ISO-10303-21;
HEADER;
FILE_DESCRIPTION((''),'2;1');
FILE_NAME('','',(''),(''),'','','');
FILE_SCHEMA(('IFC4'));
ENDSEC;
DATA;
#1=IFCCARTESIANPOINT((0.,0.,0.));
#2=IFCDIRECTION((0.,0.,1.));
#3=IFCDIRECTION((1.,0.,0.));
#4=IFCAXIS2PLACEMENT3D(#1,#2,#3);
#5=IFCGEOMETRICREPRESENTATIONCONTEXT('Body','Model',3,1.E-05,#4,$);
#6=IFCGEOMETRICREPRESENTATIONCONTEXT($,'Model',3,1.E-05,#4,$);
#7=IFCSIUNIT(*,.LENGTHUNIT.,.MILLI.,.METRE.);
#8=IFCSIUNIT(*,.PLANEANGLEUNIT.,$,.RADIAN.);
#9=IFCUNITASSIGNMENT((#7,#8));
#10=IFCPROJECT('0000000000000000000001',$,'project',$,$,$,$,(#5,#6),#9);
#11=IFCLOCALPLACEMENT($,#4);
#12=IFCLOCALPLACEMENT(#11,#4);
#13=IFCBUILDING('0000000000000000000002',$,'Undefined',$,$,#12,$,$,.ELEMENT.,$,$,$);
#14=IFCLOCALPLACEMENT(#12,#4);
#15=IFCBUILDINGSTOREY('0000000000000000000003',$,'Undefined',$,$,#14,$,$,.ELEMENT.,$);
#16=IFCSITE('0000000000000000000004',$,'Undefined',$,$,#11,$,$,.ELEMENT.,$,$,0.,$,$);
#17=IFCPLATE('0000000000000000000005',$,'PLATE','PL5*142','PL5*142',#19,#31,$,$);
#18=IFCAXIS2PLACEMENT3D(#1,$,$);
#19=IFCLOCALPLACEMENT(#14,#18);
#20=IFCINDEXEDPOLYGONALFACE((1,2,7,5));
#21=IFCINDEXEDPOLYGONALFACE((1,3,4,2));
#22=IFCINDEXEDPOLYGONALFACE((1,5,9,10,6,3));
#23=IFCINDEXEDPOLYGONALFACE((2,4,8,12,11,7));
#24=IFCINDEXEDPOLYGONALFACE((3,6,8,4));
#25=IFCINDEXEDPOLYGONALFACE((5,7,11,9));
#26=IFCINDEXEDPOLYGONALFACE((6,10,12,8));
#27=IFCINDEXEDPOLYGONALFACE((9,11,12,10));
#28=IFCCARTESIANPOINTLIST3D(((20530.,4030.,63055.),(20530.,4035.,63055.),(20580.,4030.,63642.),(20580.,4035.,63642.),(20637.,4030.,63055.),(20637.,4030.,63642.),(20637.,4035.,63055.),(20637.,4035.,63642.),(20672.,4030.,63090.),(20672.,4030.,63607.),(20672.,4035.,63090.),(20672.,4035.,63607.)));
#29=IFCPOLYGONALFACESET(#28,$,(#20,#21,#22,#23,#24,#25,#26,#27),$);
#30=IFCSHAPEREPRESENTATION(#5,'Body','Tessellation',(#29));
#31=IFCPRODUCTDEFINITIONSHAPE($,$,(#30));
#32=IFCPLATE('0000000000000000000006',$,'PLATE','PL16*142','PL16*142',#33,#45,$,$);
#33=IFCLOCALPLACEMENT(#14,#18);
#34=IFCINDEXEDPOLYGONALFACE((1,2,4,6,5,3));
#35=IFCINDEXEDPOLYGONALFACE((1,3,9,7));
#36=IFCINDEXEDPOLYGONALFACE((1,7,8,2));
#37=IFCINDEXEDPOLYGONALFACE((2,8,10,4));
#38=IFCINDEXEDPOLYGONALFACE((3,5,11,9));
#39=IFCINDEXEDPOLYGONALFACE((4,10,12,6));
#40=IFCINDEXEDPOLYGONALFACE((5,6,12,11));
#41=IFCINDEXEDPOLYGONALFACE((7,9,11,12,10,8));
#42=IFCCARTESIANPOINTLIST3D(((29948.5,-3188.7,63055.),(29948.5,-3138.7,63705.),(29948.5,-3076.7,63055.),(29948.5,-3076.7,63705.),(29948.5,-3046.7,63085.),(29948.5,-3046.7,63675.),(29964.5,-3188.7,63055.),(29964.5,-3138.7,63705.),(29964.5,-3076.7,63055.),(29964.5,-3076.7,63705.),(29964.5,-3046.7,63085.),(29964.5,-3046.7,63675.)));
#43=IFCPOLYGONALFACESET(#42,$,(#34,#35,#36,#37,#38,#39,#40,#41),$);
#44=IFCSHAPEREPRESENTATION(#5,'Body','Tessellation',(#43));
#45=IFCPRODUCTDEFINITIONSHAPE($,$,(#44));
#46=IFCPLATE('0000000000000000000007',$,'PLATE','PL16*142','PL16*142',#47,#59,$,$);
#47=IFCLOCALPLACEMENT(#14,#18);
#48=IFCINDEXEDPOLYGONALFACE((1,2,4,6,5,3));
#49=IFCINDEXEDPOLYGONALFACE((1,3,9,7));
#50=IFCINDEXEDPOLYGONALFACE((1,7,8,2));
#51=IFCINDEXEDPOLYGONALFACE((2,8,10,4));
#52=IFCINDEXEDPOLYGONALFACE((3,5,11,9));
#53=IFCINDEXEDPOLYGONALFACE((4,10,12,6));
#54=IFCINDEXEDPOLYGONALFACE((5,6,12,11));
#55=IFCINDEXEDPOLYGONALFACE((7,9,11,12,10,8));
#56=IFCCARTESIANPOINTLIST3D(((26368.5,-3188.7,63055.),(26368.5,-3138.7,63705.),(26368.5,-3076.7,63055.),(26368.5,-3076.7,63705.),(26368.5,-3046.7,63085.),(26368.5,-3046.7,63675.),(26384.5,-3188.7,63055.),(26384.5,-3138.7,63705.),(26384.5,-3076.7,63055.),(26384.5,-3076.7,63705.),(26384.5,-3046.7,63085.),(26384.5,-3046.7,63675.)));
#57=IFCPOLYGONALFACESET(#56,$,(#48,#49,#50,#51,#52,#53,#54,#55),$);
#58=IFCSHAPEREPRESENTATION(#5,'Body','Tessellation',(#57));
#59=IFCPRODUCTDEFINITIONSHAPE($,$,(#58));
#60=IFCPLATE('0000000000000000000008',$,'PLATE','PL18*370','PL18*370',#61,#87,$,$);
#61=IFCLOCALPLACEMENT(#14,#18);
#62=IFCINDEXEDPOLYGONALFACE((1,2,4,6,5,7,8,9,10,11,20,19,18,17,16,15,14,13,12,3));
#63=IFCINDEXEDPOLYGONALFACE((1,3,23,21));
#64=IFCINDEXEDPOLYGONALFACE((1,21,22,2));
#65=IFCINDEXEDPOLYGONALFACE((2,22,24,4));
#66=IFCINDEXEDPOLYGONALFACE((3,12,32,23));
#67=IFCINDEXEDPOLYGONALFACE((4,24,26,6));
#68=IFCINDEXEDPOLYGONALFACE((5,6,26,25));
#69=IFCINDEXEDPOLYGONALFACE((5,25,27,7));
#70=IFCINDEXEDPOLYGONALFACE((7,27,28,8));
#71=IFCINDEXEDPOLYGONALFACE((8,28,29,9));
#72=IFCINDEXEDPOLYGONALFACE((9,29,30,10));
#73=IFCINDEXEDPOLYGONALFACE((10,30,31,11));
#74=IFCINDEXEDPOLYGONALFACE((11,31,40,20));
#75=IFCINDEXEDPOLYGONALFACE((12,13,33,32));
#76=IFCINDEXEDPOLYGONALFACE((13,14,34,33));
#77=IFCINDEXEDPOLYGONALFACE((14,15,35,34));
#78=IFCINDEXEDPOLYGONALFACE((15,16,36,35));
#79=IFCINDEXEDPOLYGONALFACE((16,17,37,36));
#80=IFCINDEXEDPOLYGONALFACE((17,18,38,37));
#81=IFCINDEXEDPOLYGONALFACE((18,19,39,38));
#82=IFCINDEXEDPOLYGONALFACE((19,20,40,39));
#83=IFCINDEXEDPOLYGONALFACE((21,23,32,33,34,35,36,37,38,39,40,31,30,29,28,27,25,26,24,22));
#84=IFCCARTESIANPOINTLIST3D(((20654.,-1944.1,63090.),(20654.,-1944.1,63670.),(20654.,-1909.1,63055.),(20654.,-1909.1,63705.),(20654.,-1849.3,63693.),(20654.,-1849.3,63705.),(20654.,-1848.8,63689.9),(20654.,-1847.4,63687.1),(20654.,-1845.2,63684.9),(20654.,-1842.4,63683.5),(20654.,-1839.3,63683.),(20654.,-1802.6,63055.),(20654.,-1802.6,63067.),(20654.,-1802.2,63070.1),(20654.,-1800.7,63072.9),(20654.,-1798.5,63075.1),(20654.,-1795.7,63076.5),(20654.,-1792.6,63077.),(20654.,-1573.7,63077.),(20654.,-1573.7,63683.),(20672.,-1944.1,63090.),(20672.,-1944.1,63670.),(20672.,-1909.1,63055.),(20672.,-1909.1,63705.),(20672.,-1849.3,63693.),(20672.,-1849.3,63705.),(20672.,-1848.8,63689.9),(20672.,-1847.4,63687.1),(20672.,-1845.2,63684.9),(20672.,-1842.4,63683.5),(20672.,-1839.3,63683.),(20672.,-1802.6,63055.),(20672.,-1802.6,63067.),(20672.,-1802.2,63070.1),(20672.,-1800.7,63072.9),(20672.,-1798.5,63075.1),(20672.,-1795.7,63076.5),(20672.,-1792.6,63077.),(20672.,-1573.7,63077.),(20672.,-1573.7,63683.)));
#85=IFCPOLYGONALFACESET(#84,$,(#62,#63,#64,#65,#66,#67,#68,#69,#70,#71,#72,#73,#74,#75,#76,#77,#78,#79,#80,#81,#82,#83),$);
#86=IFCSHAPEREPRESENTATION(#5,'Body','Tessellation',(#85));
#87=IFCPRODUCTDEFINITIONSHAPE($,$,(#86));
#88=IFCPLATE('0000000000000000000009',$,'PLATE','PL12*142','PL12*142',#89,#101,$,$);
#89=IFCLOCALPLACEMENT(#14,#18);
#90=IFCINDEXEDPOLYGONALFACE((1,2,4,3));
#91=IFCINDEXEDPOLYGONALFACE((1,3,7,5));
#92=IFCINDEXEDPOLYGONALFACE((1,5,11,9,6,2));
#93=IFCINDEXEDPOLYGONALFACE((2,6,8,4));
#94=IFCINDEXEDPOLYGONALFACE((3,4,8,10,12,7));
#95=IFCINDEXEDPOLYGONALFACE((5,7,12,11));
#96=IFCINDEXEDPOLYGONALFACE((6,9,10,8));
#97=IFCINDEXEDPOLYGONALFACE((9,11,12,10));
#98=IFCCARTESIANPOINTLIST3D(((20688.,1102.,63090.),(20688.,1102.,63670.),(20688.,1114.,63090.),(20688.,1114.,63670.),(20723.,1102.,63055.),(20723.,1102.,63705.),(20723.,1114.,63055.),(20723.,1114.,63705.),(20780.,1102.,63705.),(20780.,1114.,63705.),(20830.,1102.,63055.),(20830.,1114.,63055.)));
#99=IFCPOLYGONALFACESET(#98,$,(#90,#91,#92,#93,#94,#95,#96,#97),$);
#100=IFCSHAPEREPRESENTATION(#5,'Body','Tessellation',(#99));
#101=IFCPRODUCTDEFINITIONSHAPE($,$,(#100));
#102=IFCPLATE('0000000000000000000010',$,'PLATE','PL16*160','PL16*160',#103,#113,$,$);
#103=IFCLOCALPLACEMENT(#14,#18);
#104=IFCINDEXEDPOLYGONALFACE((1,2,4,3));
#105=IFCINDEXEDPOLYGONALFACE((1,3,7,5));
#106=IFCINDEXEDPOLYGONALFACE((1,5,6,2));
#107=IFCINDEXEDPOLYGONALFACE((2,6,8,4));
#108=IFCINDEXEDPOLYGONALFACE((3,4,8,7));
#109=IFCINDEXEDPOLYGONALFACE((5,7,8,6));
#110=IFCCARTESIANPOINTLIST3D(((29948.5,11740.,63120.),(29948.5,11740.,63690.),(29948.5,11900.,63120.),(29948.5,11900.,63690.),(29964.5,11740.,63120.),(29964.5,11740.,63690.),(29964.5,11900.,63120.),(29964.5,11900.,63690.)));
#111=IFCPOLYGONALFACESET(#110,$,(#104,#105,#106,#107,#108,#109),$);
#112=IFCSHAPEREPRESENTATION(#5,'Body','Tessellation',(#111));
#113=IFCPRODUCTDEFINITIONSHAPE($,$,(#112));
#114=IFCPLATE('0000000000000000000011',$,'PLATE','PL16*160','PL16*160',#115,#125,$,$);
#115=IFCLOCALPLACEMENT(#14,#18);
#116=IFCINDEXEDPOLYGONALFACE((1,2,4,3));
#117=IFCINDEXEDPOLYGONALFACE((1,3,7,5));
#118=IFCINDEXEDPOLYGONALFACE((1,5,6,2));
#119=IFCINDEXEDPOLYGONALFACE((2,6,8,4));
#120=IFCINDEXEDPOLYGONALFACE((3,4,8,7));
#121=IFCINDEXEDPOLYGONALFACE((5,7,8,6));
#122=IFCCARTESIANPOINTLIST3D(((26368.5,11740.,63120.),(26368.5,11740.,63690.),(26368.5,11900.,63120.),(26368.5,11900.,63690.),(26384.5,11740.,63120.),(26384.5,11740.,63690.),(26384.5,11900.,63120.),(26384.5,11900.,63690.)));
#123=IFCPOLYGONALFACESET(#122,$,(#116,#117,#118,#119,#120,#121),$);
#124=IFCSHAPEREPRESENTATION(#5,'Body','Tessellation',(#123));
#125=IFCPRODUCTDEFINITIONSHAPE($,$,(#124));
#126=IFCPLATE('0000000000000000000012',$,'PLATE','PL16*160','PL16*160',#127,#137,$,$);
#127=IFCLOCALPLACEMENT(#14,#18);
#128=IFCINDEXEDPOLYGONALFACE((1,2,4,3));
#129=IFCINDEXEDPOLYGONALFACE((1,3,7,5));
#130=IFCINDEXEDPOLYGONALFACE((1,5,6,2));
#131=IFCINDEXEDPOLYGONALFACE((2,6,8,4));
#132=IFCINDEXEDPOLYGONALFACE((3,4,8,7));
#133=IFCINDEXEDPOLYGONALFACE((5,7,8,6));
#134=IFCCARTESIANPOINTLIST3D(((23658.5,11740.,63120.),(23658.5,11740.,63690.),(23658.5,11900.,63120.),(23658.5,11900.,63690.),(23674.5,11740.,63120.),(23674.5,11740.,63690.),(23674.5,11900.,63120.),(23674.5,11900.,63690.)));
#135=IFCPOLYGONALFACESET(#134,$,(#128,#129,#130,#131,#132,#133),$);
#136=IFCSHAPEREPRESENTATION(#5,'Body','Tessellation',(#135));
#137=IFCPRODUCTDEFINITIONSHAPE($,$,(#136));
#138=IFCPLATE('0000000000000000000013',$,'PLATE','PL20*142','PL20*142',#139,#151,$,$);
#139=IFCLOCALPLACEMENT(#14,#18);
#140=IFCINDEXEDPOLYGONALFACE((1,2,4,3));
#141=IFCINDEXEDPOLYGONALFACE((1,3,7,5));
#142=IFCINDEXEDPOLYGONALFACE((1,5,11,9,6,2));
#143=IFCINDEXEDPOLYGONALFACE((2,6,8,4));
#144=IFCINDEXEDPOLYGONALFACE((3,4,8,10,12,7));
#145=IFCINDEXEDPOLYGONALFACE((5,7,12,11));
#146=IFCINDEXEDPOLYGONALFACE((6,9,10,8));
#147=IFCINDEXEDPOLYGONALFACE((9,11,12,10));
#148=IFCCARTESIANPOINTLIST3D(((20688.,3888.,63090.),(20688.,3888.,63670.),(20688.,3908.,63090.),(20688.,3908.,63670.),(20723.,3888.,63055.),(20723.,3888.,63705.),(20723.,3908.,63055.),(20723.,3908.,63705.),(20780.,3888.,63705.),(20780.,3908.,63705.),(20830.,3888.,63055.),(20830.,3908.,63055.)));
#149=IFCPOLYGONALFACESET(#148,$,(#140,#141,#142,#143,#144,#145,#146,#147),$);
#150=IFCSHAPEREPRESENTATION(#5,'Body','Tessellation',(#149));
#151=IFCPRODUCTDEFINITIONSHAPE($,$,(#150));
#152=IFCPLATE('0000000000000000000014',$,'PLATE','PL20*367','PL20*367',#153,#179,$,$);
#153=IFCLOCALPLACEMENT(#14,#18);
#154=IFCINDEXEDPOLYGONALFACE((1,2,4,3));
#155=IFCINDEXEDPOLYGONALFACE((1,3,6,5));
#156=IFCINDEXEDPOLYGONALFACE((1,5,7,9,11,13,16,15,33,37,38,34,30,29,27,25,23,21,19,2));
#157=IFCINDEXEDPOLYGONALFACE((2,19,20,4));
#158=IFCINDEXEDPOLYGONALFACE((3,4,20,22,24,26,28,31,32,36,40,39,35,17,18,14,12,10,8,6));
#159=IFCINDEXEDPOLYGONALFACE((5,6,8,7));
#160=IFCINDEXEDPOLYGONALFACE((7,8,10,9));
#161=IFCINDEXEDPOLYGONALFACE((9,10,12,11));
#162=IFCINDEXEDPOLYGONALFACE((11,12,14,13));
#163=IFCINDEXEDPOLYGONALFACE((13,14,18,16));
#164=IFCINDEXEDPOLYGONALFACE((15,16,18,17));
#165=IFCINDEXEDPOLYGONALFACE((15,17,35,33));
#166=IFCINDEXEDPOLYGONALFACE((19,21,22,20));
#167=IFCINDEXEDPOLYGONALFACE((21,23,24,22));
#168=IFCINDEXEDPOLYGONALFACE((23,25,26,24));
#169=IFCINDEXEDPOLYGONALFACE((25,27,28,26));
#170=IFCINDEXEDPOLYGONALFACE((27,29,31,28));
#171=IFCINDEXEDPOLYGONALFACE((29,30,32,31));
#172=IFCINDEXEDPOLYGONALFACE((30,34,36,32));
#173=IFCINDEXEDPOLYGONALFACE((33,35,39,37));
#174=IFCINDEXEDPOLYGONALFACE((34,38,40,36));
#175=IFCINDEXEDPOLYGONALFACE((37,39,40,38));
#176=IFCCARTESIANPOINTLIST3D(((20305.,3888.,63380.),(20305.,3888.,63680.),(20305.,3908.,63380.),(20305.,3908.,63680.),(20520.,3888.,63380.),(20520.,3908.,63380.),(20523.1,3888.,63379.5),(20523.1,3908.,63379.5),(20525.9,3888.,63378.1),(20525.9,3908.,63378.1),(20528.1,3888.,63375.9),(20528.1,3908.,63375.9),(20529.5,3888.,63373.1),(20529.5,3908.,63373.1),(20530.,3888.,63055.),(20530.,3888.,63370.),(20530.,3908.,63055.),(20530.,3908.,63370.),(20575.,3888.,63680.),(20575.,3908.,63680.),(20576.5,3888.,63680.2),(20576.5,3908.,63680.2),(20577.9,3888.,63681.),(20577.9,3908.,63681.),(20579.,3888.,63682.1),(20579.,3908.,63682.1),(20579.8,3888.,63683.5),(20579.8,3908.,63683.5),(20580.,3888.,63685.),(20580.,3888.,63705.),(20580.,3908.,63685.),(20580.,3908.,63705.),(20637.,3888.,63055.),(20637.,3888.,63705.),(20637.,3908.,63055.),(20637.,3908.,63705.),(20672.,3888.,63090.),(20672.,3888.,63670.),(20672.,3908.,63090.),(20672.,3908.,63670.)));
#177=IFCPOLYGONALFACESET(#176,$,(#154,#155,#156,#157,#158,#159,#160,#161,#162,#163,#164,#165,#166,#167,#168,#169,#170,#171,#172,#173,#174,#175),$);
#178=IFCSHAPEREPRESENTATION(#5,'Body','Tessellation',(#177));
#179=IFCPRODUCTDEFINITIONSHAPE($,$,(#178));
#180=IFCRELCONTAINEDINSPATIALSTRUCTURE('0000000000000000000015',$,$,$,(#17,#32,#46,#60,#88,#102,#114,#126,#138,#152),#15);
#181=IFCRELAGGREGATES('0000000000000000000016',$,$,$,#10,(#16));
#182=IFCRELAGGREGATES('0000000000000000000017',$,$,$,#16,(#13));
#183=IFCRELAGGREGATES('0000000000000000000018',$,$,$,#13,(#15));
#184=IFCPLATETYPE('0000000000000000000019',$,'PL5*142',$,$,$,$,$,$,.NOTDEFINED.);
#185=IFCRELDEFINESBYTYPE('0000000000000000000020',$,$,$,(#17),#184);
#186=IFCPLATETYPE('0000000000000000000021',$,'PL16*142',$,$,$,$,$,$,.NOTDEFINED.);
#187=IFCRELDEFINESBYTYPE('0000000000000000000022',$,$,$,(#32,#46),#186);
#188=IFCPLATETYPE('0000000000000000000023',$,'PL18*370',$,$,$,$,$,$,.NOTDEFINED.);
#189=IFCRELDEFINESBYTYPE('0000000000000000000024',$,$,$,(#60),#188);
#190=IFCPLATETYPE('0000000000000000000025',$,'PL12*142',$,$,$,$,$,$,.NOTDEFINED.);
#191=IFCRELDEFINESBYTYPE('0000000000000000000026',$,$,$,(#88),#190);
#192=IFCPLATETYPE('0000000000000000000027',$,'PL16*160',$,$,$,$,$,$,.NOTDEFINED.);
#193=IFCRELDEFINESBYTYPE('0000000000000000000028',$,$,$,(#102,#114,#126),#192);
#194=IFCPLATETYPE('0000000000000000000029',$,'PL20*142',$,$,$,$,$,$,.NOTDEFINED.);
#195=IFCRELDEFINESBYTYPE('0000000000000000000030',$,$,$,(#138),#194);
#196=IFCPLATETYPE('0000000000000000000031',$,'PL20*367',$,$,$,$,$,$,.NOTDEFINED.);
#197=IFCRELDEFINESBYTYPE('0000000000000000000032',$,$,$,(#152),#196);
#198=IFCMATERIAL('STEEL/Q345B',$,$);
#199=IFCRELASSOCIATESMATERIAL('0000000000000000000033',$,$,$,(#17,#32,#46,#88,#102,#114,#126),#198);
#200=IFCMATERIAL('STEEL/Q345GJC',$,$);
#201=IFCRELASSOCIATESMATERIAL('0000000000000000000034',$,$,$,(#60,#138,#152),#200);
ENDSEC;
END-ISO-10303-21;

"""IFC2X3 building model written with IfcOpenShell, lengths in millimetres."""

from ifc_helpers import new_model, si_unit, frame, origin_with_axes, place, context, project, spatial, polyline, outline, extrude, material, type_object, element, save


model = new_model("IFC2X3")

# Units and contexts
model_context_1 = context("Model", 3, precision=1e-05, world=origin_with_axes(), identifier="Body")
model_context_2 = context("Model", 3, precision=1e-05, world=origin_with_axes())
ifc_project = project(units=[si_unit("LENGTHUNIT", "METRE", prefix="MILLI"), si_unit("PLANEANGLEUNIT", "RADIAN")], contexts=[model_context_1, model_context_2])

# Site, building, storey
site_placement = place(None, origin_with_axes())
site = spatial("IfcSite", under=ifc_project, at=site_placement, Name="Undefined", CompositionType="ELEMENT", RefElevation=0.0)
building_placement = place(site_placement, origin_with_axes())
building = spatial("IfcBuilding", under=site, at=building_placement, Name="Undefined", CompositionType="ELEMENT")
storey_placement = place(building_placement, origin_with_axes())
storey = spatial("IfcBuildingStorey", under=building, at=storey_placement, Name="Undefined", CompositionType="ELEMENT")

# Shared definitions
ifc_material_1 = material(Name="STEEL/Q345B")
ifc_material_2 = material(Name="STEEL/Q345GJC")

# Plates
plate_type_1 = type_object("IfcPlateType", Name="PL5*142", PredefinedType="NOTDEFINED")
for number, where, z_axis, x_axis, name in (
    (1, (20672.0, 4032.5, 63642.0), (0.0, -1.0, 0.0), (-1.0, 0.0, 0.0), "PLATE"),
):
    element("IfcPlate", number, at=place(storey_placement, frame(where, z_axis=z_axis, x_axis=x_axis)), inside=storey, type_object=plate_type_1, material=ifc_material_1, Name=name, Description="PL5*142", ObjectType="PL5*142", context=model_context_1, shape_type="SweptSolid", body=[
        extrude(outline(polyline([(0.0, 35.0), (35.0, 0.0), (92.0, 0.0), (142.0, 587.0), (35.0, 587.0), (0.0, 552.0), (0.0, 35.0)])), frame((0.0, 0.0, -2.5), z_axis=(0.0, 0.0, 1.0), x_axis=(1.0, 0.0, 0.0)), (0.0, 0.0, 1.0), 5.0),
    ])
plate_type_2 = type_object("IfcPlateType", Name="PL16*142", PredefinedType="NOTDEFINED")
for number, where, z_axis, x_axis, name in (
    (2, (29956.5, -3046.7, 63055.0), (-1.0, 0.0, 0.0), (0.0, -1.0, 0.0), "PLATE"),
    (3, (26376.5, -3046.7, 63055.0), (-1.0, 0.0, 0.0), (0.0, -1.0, 0.0), "PLATE"),
):
    element("IfcPlate", number, at=place(storey_placement, frame(where, z_axis=z_axis, x_axis=x_axis)), inside=storey, type_object=plate_type_2, material=ifc_material_1, Name=name, Description="PL16*142", ObjectType="PL16*142", context=model_context_1, shape_type="SweptSolid", body=[
        extrude(outline(polyline([(0.0, 30.0), (30.0, 0.0), (142.0, 0.0), (92.0, 650.0), (30.0, 650.0), (0.0, 620.0), (0.0, 30.0)])), frame((0.0, 0.0, -8.0), z_axis=(0.0, 0.0, 1.0), x_axis=(1.0, 0.0, 0.0)), (0.0, 0.0, 1.0), 16.0),
    ])
plate_type_3 = type_object("IfcPlateType", Name="PL18*370", PredefinedType="NOTDEFINED")
plate_1_placement = place(storey_placement, frame((20663.0, -1849.3, 63705.0), z_axis=(1.0, 0.0, 0.0), x_axis=(0.0, -1.0, 0.0)))
element("IfcPlate", 4, at=plate_1_placement, inside=storey, type_object=plate_type_3, material=ifc_material_2, Name="PLATE", Description="PL18*370", ObjectType="PL18*370", context=model_context_1, shape_type="SweptSolid", body=[
    extrude(outline(polyline([(0.0, 0.0), (59.8, 0.0), (94.8, 35.0), (94.8, 615.0), (59.8, 650.0), (-46.7, 650.0), (-46.7, 638.0), (-47.2, 634.9), (-48.6, 632.1), (-50.8, 629.9), (-53.6, 628.5), (-56.7, 628.0), (-275.6, 628.0), (-275.6, 22.0), (-10.0, 22.0), (-6.9, 21.5), (-4.1, 20.1), (-1.9, 17.9), (-0.5, 15.1), (0.0, 12.0), (0.0, 0.0)])), frame((0.0, 0.0, -9.0), z_axis=(0.0, 0.0, 1.0), x_axis=(1.0, 0.0, 0.0)), (0.0, 0.0, 1.0), 18.0),
])
plate_type_4 = type_object("IfcPlateType", Name="PL12*142", PredefinedType="NOTDEFINED")
plate_2_placement = place(storey_placement, frame((20830.0, 1108.0, 63055.0), z_axis=(0.0, 1.0, 0.0), x_axis=(-1.0, 0.0, 0.0)))
element("IfcPlate", 5, at=plate_2_placement, inside=storey, type_object=plate_type_4, material=ifc_material_1, Name="PLATE", Description="PL12*142", ObjectType="PL12*142", context=model_context_1, shape_type="SweptSolid", body=[
    extrude(outline(polyline([(0.0, 0.0), (107.0, 0.0), (142.0, 35.0), (142.0, 615.0), (107.0, 650.0), (50.0, 650.0), (0.0, 0.0)])), frame((0.0, 0.0, -6.0), z_axis=(0.0, 0.0, 1.0), x_axis=(1.0, 0.0, 0.0)), (0.0, 0.0, 1.0), 12.0),
])
plate_type_5 = type_object("IfcPlateType", Name="PL16*160", PredefinedType="NOTDEFINED")
for number, where, z_axis, x_axis, name in (
    (6, (29956.5, 11740.0, 63690.0), (-1.0, 0.0, 0.0), (0.0, 1.0, 0.0), "PLATE"),
    (7, (26376.5, 11740.0, 63690.0), (-1.0, 0.0, 0.0), (0.0, 1.0, 0.0), "PLATE"),
    (8, (23666.5, 11740.0, 63690.0), (-1.0, 0.0, 0.0), (0.0, 1.0, 0.0), "PLATE"),
):
    element("IfcPlate", number, at=place(storey_placement, frame(where, z_axis=z_axis, x_axis=x_axis)), inside=storey, type_object=plate_type_5, material=ifc_material_1, Name=name, Description="PL16*160", ObjectType="PL16*160", context=model_context_1, shape_type="SweptSolid", body=[
        extrude(outline(polyline([(0.0, 0.0), (160.0, 0.0), (160.0, 570.0), (0.0, 570.0), (0.0, 0.0)])), frame((0.0, 0.0, -8.0), z_axis=(0.0, 0.0, 1.0), x_axis=(1.0, 0.0, 0.0)), (0.0, 0.0, 1.0), 16.0),
    ])
plate_type_6 = type_object("IfcPlateType", Name="PL20*142", PredefinedType="NOTDEFINED")
plate_3_placement = place(storey_placement, frame((20830.0, 3898.0, 63055.0), z_axis=(0.0, 1.0, 0.0), x_axis=(-1.0, 0.0, 0.0)))
element("IfcPlate", 9, at=plate_3_placement, inside=storey, type_object=plate_type_6, material=ifc_material_2, Name="PLATE", Description="PL20*142", ObjectType="PL20*142", context=model_context_1, shape_type="SweptSolid", body=[
    extrude(outline(polyline([(0.0, 0.0), (107.0, 0.0), (142.0, 35.0), (142.0, 615.0), (107.0, 650.0), (50.0, 650.0), (0.0, 0.0)])), frame((0.0, 0.0, -10.0), z_axis=(0.0, 0.0, 1.0), x_axis=(1.0, 0.0, 0.0)), (0.0, 0.0, 1.0), 20.0),
])
plate_type_7 = type_object("IfcPlateType", Name="PL20*367", PredefinedType="NOTDEFINED")
plate_4_placement = place(storey_placement, frame((20672.0, 3898.0, 63090.0), z_axis=(0.0, 1.0, 0.0), x_axis=(-0.707107, 0.0, -0.707107)))
element("IfcPlate", 10, at=plate_4_placement, inside=storey, type_object=plate_type_7, material=ifc_material_2, Name="PLATE", Description="PL20*367", ObjectType="PL20*367", context=model_context_1, shape_type="SweptSolid", body=[
    extrude(outline(polyline([(0.0, 0.0), (49.5, 0.0), (125.2, 75.7), (-97.6, 298.4), (-99.4, 300.9), (-100.4, 303.9), (-100.4, 307.0), (-99.4, 310.0), (-97.6, 312.5), (54.4, 464.6), (-157.7, 676.7), (-348.6, 485.8), (-349.9, 484.9), (-351.4, 484.4), (-352.9, 484.4), (-354.4, 484.9), (-355.7, 485.8), (-369.8, 499.9), (-410.1, 459.6), (-410.1, 410.1), (0.0, 0.0)])), frame((0.0, 0.0, -10.0), z_axis=(0.0, 0.0, 1.0), x_axis=(1.0, 0.0, 0.0)), (0.0, 0.0, 1.0), 20.0),
])

save(model, "model.ifc")
